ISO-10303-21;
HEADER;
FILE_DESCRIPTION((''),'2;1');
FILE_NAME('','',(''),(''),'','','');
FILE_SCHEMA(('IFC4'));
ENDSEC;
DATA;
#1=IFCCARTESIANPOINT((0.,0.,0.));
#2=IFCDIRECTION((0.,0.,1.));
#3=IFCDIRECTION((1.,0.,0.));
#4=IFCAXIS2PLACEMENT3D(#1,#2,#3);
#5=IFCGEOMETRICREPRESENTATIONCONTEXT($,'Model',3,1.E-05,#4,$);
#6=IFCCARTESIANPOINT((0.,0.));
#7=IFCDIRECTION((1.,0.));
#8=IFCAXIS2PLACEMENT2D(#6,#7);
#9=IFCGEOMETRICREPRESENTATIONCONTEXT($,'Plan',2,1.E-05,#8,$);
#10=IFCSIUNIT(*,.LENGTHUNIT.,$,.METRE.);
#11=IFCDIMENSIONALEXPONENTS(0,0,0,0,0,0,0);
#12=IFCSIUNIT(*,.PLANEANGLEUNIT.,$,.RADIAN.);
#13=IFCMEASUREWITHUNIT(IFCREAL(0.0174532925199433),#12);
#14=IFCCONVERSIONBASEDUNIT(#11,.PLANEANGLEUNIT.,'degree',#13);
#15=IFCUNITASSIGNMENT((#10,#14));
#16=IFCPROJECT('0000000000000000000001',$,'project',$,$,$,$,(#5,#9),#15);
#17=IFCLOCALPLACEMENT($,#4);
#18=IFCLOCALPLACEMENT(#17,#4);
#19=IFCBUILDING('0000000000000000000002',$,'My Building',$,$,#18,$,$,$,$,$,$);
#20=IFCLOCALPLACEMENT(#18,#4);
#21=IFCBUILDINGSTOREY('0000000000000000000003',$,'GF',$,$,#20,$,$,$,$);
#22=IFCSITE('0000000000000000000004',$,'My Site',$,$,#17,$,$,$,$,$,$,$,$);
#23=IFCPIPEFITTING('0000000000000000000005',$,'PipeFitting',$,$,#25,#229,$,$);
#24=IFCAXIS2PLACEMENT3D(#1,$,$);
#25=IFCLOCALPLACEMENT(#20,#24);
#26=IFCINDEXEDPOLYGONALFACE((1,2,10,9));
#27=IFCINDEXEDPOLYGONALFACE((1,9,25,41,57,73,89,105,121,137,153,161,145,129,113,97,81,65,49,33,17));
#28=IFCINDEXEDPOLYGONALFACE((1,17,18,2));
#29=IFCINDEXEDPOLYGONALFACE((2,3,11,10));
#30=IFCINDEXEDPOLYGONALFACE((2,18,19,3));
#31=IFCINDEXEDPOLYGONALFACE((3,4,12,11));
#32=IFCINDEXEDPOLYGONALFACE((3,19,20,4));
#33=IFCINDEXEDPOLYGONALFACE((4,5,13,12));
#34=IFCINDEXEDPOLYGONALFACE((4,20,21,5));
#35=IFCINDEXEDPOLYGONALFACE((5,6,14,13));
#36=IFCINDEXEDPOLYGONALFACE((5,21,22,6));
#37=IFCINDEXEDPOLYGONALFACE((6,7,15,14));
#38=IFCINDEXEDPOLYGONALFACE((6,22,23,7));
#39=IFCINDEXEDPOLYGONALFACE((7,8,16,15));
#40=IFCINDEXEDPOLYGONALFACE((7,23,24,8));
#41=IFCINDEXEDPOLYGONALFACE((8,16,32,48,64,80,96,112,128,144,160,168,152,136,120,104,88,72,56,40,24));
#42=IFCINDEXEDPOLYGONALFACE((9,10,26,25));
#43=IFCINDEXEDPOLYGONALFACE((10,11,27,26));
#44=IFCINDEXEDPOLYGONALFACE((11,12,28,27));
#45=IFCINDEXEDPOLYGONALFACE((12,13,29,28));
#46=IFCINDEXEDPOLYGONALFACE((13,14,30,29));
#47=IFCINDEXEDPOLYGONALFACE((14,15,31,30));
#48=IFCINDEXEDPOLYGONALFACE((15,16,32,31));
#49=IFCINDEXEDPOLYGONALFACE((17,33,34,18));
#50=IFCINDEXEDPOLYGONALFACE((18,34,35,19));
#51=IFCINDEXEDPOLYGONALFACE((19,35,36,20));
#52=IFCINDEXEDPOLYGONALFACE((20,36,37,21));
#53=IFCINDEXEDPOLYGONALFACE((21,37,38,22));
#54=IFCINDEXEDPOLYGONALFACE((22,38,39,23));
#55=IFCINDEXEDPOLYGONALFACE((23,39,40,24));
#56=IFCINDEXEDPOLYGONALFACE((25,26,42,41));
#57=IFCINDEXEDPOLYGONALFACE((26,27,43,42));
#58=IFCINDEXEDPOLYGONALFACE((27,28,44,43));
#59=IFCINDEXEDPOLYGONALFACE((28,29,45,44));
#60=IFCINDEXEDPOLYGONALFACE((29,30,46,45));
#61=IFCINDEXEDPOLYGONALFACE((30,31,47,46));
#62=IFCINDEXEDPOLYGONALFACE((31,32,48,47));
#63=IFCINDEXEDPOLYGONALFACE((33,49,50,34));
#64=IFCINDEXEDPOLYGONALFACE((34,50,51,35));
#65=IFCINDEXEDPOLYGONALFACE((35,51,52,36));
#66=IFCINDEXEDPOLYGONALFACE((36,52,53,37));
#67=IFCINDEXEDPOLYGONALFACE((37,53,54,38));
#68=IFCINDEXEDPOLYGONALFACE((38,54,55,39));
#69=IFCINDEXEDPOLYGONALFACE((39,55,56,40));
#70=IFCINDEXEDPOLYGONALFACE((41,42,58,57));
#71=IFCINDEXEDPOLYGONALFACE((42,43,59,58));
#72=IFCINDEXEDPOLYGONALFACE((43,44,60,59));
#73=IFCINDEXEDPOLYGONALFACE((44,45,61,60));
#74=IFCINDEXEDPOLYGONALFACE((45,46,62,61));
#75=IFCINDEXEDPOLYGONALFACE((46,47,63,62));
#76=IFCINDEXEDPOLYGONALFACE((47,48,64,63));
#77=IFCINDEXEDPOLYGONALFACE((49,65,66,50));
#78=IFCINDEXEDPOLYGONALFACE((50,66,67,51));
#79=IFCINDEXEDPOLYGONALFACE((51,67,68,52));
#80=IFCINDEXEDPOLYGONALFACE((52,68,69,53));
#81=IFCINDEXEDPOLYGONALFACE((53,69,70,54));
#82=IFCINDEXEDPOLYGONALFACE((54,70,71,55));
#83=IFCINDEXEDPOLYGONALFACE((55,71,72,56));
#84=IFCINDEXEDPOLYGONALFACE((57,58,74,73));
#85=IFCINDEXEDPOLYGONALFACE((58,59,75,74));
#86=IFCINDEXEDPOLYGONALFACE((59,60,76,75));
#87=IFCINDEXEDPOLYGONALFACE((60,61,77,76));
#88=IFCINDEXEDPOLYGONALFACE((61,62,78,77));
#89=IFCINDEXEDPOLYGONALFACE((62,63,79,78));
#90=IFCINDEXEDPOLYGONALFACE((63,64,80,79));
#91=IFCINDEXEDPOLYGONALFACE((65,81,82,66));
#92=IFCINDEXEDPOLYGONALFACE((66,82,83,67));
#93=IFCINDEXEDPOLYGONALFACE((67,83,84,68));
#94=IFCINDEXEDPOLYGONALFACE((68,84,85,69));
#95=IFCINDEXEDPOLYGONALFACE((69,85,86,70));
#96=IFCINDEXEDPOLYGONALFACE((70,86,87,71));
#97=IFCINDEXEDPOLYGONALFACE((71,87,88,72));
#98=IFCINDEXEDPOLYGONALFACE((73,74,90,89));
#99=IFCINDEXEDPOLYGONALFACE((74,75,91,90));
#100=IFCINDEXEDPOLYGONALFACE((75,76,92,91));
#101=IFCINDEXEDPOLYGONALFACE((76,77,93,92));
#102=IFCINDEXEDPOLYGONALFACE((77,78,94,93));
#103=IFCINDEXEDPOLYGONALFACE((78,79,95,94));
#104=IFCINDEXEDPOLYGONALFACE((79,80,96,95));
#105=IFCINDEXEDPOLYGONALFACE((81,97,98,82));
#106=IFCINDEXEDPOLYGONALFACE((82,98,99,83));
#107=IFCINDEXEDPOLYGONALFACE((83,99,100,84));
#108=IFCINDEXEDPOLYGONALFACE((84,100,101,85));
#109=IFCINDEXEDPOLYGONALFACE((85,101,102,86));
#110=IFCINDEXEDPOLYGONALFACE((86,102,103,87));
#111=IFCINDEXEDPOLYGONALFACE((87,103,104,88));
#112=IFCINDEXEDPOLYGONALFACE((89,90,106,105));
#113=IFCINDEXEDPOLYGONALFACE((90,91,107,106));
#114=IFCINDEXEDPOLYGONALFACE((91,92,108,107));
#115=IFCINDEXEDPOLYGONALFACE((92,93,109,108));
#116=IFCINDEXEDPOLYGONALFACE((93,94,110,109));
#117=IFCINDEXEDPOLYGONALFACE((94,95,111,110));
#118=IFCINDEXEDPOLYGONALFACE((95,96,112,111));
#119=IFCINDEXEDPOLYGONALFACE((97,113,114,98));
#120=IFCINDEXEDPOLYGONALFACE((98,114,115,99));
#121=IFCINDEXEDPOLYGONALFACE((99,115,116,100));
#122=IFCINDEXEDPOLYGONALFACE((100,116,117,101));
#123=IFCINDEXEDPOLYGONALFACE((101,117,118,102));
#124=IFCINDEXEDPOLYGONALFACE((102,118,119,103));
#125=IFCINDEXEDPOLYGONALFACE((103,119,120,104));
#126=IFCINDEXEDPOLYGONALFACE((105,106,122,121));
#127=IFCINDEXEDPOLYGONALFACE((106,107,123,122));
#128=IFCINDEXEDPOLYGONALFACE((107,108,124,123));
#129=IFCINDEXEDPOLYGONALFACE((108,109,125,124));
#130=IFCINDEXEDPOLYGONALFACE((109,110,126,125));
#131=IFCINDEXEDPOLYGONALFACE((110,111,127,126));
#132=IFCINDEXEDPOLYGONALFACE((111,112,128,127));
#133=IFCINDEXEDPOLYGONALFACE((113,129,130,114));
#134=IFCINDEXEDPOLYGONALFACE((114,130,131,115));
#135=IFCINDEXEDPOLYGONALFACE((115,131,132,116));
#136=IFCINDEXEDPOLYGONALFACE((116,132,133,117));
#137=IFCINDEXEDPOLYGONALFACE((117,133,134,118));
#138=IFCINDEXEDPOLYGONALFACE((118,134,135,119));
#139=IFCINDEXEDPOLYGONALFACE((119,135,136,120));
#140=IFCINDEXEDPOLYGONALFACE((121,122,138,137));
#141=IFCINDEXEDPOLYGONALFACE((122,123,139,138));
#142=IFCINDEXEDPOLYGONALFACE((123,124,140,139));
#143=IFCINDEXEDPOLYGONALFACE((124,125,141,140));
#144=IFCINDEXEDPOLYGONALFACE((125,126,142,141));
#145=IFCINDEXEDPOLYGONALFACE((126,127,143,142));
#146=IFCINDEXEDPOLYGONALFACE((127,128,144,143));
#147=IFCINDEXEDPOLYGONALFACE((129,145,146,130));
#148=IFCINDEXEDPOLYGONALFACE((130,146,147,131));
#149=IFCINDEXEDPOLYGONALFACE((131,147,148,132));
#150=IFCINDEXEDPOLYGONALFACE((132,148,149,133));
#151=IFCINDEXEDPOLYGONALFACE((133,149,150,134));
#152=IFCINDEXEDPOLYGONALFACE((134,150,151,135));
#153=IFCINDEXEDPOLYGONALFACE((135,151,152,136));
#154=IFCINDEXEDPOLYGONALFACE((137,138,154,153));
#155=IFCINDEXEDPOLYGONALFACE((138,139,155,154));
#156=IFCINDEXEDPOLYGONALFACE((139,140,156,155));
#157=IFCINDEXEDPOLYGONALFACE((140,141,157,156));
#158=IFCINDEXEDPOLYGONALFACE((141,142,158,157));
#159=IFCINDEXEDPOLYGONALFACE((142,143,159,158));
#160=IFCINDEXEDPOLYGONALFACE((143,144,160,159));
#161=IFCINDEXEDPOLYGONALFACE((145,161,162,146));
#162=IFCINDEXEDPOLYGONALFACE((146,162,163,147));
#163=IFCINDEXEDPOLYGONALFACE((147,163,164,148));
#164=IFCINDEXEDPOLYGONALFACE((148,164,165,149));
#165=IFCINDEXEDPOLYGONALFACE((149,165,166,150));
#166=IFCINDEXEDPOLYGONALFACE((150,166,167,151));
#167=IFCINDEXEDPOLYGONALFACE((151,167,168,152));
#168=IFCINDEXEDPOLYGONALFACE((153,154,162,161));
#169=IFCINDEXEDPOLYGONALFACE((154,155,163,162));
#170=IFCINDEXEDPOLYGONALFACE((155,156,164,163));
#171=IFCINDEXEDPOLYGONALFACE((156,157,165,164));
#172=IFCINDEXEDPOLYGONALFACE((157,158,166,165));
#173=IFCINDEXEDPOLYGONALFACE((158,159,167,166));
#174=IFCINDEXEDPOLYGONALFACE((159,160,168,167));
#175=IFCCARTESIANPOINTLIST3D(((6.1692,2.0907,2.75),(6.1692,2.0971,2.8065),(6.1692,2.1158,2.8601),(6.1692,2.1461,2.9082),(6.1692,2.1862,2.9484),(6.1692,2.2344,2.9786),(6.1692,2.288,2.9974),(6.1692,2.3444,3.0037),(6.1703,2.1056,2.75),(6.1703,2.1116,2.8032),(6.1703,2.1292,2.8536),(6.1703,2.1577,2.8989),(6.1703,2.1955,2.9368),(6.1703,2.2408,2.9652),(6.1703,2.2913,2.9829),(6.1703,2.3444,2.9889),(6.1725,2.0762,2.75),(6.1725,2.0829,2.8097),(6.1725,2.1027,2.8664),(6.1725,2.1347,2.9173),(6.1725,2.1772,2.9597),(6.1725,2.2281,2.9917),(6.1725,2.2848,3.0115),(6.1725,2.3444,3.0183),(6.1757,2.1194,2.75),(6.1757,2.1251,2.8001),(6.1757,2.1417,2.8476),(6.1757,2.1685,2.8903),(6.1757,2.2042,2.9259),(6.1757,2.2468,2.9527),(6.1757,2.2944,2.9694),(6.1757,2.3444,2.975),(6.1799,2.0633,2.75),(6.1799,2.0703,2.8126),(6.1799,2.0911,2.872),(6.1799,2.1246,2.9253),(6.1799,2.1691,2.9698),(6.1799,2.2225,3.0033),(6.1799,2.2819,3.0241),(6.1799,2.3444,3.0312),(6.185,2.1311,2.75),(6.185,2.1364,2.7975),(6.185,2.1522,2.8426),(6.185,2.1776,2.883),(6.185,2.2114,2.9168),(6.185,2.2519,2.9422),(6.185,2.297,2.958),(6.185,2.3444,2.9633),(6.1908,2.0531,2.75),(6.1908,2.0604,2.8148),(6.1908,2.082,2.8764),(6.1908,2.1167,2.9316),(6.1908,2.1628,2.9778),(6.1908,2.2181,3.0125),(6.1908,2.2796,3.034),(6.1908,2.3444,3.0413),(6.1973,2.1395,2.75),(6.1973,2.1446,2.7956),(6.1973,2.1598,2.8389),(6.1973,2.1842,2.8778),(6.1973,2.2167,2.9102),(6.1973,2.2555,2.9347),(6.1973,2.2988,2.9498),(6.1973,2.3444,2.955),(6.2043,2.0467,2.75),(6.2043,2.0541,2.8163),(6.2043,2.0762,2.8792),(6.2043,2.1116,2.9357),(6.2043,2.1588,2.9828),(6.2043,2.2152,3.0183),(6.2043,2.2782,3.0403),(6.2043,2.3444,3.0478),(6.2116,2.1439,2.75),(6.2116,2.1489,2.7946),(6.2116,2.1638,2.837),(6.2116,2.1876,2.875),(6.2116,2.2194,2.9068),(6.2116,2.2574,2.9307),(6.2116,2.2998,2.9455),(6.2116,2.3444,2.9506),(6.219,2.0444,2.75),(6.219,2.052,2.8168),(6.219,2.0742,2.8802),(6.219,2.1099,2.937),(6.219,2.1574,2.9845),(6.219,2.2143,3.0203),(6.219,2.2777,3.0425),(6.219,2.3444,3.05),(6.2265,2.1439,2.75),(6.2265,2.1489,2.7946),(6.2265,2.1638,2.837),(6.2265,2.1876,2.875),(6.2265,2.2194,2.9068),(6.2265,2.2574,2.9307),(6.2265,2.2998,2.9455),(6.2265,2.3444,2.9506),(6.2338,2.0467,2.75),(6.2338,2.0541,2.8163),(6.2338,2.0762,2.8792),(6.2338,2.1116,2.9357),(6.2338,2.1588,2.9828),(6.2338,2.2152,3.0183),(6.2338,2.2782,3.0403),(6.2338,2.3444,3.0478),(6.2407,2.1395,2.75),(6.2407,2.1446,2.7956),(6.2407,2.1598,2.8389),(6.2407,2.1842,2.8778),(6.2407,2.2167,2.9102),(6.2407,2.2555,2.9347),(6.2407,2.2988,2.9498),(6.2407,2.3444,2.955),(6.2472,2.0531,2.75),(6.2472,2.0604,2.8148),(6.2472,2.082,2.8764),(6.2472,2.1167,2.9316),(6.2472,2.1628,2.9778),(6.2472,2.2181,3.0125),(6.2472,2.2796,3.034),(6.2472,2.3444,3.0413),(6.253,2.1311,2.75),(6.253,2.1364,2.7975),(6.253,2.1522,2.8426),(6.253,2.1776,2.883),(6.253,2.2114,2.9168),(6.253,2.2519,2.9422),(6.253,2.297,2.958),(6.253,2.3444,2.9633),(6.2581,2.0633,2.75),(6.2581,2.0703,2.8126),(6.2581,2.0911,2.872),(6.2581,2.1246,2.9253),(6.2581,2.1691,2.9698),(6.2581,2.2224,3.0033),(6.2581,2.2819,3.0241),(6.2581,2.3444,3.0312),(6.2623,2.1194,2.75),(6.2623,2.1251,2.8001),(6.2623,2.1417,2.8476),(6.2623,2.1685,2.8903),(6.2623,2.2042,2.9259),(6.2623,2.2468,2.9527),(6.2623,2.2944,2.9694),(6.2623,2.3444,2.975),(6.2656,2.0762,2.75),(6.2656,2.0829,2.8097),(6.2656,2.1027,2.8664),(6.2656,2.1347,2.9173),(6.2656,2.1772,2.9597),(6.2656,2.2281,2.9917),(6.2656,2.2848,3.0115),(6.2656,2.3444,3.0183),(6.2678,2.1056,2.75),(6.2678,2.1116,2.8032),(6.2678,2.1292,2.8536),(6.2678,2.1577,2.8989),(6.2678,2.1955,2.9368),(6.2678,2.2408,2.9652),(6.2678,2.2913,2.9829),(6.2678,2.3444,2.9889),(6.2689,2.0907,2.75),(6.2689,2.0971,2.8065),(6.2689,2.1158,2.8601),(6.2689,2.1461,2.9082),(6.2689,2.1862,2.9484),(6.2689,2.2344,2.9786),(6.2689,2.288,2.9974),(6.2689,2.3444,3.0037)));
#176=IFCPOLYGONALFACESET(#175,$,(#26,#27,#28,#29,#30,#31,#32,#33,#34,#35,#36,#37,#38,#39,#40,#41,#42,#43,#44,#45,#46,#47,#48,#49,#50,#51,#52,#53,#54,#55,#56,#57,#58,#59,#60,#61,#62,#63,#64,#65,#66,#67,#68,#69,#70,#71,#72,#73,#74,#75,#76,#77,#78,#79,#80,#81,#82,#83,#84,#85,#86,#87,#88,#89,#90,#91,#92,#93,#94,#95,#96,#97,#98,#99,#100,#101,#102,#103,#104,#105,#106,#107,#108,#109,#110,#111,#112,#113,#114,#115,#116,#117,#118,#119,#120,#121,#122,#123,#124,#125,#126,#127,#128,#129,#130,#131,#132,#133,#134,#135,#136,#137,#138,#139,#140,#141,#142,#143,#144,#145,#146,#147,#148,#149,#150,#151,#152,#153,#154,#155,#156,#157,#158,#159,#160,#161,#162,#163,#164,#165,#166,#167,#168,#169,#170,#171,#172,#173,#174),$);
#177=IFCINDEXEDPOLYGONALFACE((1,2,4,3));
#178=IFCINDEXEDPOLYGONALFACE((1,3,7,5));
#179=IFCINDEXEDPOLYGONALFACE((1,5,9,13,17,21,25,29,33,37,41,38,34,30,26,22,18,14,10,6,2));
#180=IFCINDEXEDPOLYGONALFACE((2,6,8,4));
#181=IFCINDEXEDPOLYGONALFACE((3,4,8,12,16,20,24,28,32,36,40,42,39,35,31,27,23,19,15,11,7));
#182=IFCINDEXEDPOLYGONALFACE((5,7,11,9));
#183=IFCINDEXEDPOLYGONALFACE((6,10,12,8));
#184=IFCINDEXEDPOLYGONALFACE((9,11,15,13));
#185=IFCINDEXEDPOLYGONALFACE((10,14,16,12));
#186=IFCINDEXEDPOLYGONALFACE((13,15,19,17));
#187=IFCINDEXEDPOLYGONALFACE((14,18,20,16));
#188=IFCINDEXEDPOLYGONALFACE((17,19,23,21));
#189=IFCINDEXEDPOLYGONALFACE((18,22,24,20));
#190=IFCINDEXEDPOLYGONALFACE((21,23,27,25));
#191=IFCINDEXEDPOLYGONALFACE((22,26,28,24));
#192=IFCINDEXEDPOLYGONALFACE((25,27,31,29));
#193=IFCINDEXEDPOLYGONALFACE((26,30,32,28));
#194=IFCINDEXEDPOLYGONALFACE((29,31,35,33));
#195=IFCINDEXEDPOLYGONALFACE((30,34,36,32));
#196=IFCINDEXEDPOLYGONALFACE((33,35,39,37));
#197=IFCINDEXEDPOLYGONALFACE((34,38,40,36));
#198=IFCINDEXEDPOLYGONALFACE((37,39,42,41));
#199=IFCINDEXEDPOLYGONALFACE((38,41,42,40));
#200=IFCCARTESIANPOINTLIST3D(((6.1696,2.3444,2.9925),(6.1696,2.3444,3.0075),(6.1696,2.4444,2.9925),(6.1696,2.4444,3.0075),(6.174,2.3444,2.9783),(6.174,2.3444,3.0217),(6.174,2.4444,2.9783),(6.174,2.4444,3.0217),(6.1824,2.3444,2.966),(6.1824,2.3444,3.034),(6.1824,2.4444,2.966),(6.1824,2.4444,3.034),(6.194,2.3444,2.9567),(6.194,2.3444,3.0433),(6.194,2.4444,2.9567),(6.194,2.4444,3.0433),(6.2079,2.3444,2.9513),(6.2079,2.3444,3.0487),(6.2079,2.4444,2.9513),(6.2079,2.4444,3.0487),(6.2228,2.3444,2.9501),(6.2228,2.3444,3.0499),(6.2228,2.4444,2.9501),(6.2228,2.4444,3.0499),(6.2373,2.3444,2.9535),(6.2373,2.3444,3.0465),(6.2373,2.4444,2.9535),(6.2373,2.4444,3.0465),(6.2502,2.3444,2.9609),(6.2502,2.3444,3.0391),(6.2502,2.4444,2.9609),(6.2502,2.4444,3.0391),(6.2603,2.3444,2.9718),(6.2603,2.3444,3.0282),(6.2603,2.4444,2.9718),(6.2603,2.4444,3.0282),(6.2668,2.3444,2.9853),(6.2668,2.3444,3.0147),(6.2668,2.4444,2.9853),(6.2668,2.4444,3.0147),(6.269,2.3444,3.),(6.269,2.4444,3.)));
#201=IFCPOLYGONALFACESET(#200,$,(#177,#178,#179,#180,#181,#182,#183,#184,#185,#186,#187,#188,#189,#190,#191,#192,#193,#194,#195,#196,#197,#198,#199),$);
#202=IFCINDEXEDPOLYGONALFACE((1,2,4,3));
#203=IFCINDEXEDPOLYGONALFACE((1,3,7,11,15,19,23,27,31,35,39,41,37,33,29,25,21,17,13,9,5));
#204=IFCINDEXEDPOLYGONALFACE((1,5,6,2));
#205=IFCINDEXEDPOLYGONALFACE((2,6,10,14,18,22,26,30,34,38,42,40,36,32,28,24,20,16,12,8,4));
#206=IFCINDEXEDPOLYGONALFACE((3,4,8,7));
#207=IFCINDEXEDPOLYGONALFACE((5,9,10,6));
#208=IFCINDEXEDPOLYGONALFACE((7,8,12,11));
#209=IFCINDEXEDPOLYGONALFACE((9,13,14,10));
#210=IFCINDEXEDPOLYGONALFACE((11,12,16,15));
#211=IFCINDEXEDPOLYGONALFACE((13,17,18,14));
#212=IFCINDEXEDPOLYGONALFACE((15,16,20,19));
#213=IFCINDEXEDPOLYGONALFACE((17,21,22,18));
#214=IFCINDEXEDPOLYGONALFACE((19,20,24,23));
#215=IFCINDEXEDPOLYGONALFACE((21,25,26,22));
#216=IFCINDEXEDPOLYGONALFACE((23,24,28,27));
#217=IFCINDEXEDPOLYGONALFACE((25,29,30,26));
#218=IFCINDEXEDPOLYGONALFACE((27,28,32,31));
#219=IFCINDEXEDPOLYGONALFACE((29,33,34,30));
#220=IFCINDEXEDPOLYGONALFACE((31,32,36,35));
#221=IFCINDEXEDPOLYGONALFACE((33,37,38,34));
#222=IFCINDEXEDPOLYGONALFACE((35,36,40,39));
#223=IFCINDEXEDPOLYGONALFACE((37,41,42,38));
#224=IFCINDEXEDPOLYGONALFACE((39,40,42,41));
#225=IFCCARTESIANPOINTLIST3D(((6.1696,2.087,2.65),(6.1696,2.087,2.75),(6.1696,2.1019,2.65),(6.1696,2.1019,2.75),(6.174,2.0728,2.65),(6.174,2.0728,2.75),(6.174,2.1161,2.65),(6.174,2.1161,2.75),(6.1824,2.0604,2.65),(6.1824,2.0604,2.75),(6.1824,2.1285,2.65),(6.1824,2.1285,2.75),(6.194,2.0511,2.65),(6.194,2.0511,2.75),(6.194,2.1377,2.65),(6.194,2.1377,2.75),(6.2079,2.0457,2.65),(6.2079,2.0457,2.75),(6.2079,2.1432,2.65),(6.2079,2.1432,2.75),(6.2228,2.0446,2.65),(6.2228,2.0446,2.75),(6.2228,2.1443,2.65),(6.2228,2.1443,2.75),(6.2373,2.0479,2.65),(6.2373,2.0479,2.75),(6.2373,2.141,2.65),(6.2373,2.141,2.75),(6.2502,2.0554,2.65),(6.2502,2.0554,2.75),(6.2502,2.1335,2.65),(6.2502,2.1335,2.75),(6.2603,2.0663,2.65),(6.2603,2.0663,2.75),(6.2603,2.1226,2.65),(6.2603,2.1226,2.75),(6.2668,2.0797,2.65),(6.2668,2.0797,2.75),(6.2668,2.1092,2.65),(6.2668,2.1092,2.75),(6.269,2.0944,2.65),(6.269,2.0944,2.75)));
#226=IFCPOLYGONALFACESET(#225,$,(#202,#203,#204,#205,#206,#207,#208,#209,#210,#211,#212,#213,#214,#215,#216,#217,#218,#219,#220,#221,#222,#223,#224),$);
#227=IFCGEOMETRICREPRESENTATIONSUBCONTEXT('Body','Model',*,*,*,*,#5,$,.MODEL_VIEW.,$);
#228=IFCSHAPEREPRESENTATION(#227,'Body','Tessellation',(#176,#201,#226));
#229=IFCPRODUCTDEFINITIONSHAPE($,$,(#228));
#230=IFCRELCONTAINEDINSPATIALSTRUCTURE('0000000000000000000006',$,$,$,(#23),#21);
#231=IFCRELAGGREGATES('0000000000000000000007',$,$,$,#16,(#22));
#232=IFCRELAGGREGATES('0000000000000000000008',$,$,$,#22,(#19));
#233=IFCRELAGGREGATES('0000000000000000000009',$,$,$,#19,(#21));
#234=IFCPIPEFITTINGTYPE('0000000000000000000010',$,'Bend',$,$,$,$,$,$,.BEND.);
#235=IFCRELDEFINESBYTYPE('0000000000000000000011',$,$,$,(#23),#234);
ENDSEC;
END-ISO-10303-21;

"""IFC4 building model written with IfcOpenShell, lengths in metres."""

from ifc_helpers import new_model, entity, si_unit, converted_unit, frame, origin_with_axes, origin_2d_with_axis, place, context, subcontext, project, spatial, circle, extrude, source, transform, mapped, type_object, type_shapes, element, save


model = new_model("IFC4")

# Units and contexts
model_context = context("Model", 3, precision=1e-05, world=origin_with_axes())
plan_context = context("Plan", 2, precision=1e-05, world=origin_2d_with_axis())
body_context = subcontext(model_context, "Body", "Model", "MODEL_VIEW")
ifc_project = project(units=[si_unit("LENGTHUNIT", "METRE"), converted_unit("PLANEANGLEUNIT", "degree", entity("IfcReal", 0.0174532925199433), si_unit("PLANEANGLEUNIT", "RADIAN"), dimensions=[0, 0, 0, 0, 0, 0, 0])], contexts=[model_context, plan_context])

# Site, building, storey
site_placement = place(None, origin_with_axes())
site = spatial("IfcSite", under=ifc_project, at=site_placement, Name="My Site")
building_placement = place(site_placement, origin_with_axes())
building = spatial("IfcBuilding", under=site, at=building_placement, Name="My Building")
storey_placement = place(building_placement, origin_with_axes())
storey = spatial("IfcBuildingStorey", under=building, at=storey_placement, Name="GF")

# Pipe fitting
pipe_fitting_type = type_object("IfcPipeFittingType", Name="Bend", PredefinedType="BEND")
shared_shape = source(origin_with_axes(), body_context, "Body", "SolidModel", [
    entity("IfcSweptDiskSolid", entity("IfcIndexedPolyCurve", entity("IfcCartesianPointList3D", [[0.0, 0.0, 0.1], [0.0, -0.0732, 0.2768], [0.0, -0.25, 0.35]]), [entity("IfcArcIndex", [1, 2, 3])]), 0.05),
    extrude(circle(Radius=0.05), origin_with_axes(), (0.0, 0.0, 1.0), 0.1),
    extrude(circle(Radius=0.05), frame((0.0, -0.25, 0.35), z_axis=(0.0, -1.0, 0.0), x_axis=(1.0, 0.0, 0.0)), (0.0, 0.0, 1.0), 0.1),
])
type_shapes(pipe_fitting_type, [shared_shape])
for number, where, z_axis, x_axis, name in (
    (1, (6.219, 2.4444, 3.0), (0.0, -1.0, 0.0), (1.0, 0.0, 0.0), "PipeFitting"),
):
    element("IfcPipeFitting", number, at=place(storey_placement, frame(where, z_axis=z_axis, x_axis=x_axis)), inside=storey, type_object=pipe_fitting_type, Name=name, context=body_context, shape_type="MappedRepresentation", body=[
        mapped(shared_shape, transform((0.0, 0.0, 0.0), x_axis=(1.0, 0.0, 0.0), y_axis=(0.0, 1.0, 0.0), z_axis=(0.0, 0.0, 1.0), scale=1.0)),
    ])

save(model, "model.ifc")
